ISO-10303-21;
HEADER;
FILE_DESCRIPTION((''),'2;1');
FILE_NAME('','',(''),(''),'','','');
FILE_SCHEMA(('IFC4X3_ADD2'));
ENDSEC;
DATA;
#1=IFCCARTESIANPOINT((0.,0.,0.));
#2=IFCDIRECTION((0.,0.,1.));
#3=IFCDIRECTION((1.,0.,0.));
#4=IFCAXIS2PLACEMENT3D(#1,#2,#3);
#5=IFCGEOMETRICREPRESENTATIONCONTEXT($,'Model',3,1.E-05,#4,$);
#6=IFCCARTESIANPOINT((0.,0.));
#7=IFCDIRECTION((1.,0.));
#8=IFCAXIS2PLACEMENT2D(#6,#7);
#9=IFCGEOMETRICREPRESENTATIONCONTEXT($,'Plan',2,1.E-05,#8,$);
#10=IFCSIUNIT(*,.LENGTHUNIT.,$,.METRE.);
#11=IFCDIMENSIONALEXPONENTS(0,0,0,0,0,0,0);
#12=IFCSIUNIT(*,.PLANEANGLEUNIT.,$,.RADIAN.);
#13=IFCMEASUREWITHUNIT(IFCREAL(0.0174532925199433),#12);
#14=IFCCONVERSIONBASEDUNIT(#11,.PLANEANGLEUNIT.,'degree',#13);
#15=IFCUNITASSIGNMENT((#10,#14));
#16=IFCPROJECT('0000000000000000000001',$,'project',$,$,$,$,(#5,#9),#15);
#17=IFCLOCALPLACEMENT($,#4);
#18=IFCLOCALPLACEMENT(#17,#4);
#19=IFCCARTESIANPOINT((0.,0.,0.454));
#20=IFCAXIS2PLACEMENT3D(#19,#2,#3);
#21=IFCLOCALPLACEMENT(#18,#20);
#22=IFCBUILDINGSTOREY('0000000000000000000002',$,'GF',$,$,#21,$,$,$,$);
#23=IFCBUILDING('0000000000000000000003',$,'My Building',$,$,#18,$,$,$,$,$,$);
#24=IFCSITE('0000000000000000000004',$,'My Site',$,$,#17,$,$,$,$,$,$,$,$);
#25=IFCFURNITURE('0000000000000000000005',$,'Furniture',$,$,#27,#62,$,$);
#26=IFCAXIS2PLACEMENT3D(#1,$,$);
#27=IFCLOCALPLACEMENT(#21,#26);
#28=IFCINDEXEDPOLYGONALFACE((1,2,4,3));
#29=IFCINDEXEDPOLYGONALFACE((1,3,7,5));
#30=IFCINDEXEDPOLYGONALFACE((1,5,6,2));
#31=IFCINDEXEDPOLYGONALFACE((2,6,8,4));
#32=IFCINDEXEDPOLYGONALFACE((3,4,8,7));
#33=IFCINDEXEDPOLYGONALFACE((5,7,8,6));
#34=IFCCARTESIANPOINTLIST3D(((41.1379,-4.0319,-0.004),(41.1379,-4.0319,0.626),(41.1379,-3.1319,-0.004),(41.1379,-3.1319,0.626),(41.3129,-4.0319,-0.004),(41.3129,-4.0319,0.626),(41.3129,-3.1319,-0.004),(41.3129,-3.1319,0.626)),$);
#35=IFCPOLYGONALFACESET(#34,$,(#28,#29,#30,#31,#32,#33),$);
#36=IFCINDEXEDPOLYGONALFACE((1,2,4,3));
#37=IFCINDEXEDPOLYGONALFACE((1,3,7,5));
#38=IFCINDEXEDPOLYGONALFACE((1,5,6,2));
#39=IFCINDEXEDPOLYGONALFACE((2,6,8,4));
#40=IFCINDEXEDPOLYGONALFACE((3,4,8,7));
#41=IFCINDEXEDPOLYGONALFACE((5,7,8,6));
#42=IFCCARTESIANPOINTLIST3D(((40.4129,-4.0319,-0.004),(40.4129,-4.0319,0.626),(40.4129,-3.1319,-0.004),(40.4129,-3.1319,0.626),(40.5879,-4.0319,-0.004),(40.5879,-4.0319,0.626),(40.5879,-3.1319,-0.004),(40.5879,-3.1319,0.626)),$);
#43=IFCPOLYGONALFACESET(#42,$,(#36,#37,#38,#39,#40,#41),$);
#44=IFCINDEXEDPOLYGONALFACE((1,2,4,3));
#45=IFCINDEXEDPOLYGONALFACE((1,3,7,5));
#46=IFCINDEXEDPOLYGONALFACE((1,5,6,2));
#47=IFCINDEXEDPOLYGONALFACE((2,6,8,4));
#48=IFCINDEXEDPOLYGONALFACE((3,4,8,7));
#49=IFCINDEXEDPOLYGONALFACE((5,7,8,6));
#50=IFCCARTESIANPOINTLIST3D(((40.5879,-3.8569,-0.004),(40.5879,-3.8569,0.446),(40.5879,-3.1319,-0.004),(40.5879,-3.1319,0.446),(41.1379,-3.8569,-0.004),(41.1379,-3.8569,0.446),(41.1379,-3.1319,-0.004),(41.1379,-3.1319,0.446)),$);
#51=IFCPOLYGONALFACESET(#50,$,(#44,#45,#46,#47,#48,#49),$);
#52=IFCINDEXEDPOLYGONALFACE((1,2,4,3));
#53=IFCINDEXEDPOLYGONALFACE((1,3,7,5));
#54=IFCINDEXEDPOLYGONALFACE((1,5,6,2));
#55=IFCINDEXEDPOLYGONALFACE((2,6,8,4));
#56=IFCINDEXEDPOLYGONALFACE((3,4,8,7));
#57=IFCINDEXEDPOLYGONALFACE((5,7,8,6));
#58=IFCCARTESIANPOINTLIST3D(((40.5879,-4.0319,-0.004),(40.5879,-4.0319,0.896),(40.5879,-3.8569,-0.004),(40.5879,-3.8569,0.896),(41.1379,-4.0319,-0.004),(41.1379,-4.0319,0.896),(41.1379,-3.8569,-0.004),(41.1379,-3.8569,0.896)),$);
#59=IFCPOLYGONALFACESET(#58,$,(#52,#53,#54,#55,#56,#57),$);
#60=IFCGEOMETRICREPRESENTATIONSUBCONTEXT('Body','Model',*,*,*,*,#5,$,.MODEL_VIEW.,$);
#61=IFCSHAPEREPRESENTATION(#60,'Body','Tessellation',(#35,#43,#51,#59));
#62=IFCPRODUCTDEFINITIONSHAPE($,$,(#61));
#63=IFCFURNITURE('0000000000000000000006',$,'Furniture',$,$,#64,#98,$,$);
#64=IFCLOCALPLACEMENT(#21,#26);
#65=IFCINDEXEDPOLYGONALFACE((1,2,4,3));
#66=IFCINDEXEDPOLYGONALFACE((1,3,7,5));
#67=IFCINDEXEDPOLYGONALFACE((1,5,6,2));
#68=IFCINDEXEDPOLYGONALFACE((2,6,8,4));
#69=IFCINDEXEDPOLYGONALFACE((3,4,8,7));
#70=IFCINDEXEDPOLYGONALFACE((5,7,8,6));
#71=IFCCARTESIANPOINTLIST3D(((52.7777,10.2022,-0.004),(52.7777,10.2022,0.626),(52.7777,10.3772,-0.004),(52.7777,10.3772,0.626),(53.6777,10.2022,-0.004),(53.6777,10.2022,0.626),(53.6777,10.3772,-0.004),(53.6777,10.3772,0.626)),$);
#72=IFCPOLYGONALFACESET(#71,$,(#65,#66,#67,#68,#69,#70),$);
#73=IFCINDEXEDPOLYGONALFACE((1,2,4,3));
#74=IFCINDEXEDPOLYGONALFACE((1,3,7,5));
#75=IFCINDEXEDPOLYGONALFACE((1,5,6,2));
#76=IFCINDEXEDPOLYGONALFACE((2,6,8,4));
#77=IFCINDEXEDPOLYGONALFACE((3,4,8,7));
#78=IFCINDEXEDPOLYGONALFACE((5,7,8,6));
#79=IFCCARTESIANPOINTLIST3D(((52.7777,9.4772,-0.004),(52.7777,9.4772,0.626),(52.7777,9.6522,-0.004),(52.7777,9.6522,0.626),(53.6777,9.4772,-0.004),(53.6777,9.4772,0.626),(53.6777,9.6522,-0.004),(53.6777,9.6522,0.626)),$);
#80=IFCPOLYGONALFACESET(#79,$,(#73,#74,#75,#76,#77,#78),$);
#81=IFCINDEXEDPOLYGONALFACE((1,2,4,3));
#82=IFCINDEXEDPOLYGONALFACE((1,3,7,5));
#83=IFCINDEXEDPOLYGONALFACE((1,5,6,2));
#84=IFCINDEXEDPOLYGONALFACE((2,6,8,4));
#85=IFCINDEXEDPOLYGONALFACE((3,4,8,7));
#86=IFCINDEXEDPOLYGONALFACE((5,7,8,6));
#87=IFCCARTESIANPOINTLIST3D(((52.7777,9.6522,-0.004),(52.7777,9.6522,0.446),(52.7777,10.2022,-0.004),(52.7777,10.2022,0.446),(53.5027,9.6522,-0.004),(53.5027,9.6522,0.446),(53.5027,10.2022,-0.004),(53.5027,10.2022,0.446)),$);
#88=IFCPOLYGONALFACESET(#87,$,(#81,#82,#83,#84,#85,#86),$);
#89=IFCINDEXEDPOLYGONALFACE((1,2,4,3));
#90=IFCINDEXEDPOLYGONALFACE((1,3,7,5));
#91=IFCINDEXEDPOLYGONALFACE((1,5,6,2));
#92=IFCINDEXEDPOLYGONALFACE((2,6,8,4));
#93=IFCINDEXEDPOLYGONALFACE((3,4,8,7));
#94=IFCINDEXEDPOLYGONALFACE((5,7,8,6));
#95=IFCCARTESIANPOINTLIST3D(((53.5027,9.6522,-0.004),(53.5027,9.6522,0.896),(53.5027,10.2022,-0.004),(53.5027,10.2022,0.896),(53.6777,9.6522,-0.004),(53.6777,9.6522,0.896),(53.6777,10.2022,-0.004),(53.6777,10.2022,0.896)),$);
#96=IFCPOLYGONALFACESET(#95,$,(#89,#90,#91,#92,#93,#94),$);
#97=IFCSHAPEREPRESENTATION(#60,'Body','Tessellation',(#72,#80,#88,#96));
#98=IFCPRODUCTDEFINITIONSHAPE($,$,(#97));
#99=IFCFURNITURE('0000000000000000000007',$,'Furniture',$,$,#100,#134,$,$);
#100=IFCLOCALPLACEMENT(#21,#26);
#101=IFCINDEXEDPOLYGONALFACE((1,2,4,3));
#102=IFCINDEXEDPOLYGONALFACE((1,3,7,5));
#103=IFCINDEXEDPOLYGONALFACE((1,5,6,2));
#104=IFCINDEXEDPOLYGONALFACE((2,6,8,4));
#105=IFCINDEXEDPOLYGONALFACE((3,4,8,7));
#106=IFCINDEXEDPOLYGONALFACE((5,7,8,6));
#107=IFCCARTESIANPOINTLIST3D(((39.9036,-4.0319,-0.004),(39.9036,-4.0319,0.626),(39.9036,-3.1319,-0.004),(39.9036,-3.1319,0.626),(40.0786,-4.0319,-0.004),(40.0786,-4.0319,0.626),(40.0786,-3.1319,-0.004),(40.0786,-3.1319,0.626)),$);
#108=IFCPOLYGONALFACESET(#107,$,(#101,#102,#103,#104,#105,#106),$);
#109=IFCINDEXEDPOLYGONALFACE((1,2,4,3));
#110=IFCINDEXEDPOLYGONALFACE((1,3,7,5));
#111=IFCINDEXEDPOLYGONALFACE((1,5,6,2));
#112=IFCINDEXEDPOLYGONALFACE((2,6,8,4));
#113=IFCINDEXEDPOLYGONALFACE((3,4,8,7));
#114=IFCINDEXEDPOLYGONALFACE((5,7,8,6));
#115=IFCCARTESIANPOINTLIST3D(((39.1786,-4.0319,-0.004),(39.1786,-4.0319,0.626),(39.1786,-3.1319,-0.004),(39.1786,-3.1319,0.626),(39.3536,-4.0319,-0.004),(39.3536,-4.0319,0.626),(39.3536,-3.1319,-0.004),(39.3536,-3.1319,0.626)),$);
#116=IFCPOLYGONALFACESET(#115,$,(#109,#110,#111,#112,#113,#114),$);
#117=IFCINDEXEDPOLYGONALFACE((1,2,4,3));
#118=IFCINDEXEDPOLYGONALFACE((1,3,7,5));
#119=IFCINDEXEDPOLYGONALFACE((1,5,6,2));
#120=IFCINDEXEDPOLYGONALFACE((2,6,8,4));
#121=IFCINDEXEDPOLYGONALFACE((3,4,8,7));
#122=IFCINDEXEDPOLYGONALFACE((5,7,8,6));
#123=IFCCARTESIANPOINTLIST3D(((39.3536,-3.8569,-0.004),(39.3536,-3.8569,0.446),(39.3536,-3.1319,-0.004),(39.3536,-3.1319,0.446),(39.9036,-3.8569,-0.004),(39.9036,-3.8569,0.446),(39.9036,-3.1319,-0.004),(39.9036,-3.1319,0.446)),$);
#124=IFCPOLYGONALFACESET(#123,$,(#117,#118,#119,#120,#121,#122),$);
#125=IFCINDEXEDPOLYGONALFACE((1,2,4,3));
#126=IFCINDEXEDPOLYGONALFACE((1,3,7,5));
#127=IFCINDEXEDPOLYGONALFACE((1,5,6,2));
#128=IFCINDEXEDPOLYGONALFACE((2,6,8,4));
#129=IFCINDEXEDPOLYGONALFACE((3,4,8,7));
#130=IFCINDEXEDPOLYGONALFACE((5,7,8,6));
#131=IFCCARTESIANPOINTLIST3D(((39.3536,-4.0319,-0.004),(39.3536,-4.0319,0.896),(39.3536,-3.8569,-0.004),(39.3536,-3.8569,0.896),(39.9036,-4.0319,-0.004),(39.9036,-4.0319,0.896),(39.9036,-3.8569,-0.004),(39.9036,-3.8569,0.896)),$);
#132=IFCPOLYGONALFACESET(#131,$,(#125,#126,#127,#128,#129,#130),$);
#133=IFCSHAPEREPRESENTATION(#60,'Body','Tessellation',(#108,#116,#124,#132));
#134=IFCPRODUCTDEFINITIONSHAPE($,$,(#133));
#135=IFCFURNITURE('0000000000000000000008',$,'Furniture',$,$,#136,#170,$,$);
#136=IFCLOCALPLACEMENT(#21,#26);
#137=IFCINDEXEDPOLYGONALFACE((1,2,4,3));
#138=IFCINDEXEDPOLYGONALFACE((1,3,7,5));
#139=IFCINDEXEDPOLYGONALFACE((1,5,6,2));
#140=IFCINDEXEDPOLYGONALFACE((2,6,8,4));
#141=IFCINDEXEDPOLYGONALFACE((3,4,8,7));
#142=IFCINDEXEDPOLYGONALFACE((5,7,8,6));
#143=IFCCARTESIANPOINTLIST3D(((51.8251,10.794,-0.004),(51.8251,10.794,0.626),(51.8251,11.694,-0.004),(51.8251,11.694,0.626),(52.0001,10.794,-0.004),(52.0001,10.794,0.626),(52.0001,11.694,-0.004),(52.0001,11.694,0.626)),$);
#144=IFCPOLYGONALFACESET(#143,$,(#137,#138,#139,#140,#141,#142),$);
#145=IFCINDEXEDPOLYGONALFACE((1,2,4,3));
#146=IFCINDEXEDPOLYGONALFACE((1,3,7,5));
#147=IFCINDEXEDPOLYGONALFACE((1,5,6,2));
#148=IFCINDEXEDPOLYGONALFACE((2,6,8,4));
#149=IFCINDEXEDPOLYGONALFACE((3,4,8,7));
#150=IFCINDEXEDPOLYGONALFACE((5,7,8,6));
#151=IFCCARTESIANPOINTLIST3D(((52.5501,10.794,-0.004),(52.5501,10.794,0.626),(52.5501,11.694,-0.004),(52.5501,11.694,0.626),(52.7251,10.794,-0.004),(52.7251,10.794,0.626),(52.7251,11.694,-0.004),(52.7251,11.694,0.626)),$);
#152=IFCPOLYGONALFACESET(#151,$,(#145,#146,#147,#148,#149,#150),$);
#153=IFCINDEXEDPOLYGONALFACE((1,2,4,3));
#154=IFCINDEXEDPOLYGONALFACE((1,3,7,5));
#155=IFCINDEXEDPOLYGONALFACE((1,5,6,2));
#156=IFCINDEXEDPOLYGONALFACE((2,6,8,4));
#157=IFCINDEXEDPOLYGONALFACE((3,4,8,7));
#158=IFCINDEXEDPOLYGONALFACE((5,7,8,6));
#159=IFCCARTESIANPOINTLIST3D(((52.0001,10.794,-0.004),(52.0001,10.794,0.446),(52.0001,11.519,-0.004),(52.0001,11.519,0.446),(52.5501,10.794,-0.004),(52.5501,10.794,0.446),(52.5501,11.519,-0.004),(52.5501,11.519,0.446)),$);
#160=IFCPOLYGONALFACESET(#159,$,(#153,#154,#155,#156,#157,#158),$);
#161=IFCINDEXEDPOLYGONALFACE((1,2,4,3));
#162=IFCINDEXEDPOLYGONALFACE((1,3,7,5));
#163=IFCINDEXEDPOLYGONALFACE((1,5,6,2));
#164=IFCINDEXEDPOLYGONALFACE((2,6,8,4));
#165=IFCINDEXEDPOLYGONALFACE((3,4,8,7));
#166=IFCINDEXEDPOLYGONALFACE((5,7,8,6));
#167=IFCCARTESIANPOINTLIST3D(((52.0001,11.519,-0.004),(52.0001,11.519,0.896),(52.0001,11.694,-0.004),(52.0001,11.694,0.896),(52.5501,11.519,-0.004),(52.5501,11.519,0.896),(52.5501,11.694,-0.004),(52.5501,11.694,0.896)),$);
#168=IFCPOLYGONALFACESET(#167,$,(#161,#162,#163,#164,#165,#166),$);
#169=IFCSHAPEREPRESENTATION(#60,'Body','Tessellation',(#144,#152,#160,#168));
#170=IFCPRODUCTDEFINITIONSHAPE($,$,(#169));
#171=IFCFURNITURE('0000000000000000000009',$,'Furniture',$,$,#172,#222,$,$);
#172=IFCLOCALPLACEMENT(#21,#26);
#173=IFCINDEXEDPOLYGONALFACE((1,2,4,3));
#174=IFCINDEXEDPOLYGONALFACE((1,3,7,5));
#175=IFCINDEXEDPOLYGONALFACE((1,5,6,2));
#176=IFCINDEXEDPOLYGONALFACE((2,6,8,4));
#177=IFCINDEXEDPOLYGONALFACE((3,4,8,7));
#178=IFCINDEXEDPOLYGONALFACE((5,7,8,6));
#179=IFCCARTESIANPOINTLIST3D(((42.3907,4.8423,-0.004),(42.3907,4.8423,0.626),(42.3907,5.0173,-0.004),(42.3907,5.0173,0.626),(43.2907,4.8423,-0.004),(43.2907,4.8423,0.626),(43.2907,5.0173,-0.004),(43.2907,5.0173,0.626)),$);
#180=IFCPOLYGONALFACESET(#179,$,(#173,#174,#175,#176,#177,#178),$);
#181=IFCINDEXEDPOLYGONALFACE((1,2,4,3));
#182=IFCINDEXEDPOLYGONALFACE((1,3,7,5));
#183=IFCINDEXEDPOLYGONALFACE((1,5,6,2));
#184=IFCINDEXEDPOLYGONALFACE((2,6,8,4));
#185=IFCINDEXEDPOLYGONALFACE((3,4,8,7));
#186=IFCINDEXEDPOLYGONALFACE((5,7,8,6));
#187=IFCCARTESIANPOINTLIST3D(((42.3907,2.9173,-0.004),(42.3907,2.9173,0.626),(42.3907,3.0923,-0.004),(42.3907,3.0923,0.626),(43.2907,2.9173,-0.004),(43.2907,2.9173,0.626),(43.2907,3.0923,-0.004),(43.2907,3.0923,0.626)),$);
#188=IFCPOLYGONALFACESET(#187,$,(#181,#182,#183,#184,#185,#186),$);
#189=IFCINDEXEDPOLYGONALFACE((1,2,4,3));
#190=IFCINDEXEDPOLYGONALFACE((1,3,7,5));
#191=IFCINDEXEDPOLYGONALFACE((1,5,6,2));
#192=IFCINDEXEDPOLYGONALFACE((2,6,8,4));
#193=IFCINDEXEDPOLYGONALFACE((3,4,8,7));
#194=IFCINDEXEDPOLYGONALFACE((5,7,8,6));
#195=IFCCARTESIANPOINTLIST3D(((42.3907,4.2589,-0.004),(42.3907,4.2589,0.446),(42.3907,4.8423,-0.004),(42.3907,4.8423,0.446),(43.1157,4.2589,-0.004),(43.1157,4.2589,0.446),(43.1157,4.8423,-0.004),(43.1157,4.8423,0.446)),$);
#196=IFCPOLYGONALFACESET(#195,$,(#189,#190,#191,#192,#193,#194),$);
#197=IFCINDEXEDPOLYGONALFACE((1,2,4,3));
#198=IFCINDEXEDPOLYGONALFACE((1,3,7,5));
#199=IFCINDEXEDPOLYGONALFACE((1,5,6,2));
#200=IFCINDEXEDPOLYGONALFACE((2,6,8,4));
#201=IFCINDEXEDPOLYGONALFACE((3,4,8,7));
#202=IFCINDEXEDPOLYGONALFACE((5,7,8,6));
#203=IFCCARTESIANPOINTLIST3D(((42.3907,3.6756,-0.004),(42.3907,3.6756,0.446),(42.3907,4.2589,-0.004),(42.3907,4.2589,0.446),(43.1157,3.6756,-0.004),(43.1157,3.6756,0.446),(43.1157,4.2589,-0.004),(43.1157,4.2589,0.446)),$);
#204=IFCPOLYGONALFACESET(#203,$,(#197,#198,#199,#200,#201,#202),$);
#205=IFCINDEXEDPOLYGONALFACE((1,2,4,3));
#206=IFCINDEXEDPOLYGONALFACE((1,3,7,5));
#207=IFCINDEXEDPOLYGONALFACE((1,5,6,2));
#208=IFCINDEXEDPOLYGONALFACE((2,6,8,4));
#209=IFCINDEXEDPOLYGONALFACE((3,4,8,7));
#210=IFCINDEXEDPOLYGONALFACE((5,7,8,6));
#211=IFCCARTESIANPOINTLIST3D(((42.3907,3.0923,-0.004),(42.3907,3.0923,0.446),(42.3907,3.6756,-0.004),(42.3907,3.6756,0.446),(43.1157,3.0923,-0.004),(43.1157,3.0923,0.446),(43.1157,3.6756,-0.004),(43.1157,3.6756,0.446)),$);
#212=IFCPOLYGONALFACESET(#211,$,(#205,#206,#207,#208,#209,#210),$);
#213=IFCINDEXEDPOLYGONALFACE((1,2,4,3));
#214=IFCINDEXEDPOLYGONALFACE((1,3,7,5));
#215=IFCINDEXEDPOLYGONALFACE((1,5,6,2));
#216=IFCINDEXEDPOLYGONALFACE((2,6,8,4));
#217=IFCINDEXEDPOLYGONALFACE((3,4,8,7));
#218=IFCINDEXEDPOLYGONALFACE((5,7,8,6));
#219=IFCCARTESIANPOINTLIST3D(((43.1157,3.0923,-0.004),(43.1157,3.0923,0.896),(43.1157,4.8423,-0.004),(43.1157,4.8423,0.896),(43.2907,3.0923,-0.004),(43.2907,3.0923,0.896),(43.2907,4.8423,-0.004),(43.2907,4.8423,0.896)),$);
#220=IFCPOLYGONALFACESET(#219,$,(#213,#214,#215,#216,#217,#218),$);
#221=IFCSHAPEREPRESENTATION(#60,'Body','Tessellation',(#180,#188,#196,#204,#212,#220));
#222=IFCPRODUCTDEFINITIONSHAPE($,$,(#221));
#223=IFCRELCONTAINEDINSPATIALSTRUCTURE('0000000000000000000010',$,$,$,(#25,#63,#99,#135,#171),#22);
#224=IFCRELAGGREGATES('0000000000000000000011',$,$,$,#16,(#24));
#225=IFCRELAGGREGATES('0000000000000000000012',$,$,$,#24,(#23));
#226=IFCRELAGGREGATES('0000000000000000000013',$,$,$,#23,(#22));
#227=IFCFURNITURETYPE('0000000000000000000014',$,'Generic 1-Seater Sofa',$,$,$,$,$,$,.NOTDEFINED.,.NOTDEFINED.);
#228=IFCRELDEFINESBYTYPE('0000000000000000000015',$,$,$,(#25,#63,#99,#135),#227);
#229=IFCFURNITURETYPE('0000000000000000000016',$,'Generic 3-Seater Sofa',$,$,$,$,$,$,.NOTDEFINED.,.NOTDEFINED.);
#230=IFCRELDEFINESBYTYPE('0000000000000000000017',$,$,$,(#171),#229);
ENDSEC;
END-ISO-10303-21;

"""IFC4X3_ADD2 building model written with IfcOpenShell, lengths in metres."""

from ifc_helpers import new_model, entity, si_unit, converted_unit, frame, origin_with_axes, origin_2d_with_axis, place, context, subcontext, project, spatial, line, indexed_curve, outline, extrude, shape, source, transform, mapped, type_object, type_shapes, element, save


model = new_model("IFC4X3_ADD2")

# Units and contexts
model_context = context("Model", 3, precision=1e-05, world=origin_with_axes())
plan_context = context("Plan", 2, precision=1e-05, world=origin_2d_with_axis())
body_context_1 = subcontext(model_context, "Body", "Model", "MODEL_VIEW")
body_context_2 = subcontext(plan_context, "Body", "Plan", "PLAN_VIEW")
ifc_project = project(units=[si_unit("LENGTHUNIT", "METRE"), converted_unit("PLANEANGLEUNIT", "degree", entity("IfcReal", 0.0174532925199433), si_unit("PLANEANGLEUNIT", "RADIAN"), dimensions=[0, 0, 0, 0, 0, 0, 0])], contexts=[model_context, plan_context])

# Site, building, storey
site_placement = place(None, origin_with_axes())
site = spatial("IfcSite", under=ifc_project, at=site_placement, Name="My Site")
building_placement = place(site_placement, origin_with_axes())
building = spatial("IfcBuilding", under=site, at=building_placement, Name="My Building")
storey_placement = place(building_placement, frame((0.0, 0.0, 0.454), z_axis=(0.0, 0.0, 1.0), x_axis=(1.0, 0.0, 0.0)))
storey = spatial("IfcBuildingStorey", under=building, at=storey_placement, Name="GF")

# Furniture
furniture_type_1 = type_object("IfcFurnitureType", Name="Generic 1-Seater Sofa", AssemblyPlace="NOTDEFINED", PredefinedType="NOTDEFINED")
shared_shape_1 = source(origin_with_axes(), body_context_1, "Body", "SweptSolid", [
    extrude(outline(indexed_curve([(0.0, 0.0), (0.175, 0.0), (0.175, 0.9), (0.0, 0.9)], segments=[line(1, 2, 3, 4, 1)])), frame((-0.45, -0.9, 0.0), z_axis=(0.0, 0.0, 1.0), x_axis=(1.0, 0.0, 0.0)), (0.0, 0.0, 1.0), 0.63),
    extrude(outline(indexed_curve([(0.0, 0.0), (0.175, 0.0), (0.175, 0.9), (0.0, 0.9)], segments=[line(1, 2, 3, 4, 1)])), frame((0.275, -0.9, 0.0), z_axis=(0.0, 0.0, 1.0), x_axis=(1.0, 0.0, 0.0)), (0.0, 0.0, 1.0), 0.63),
    extrude(outline(indexed_curve([(0.175, 0.0), (0.725, 0.0), (0.725, 0.725), (0.175, 0.725)], segments=[line(1, 2, 3, 4, 1)])), frame((-0.45, -0.9, 0.0), z_axis=(0.0, 0.0, 1.0), x_axis=(1.0, 0.0, 0.0)), (0.0, 0.0, 1.0), 0.45),
    extrude(outline(indexed_curve([(0.175, 0.725), (0.725, 0.725), (0.725, 0.9), (0.175, 0.9)], segments=[line(1, 2, 3, 4, 1)])), frame((-0.45, -0.9, 0.0), z_axis=(0.0, 0.0, 1.0), x_axis=(1.0, 0.0, 0.0)), (0.0, 0.0, 1.0), 0.9),
])
shared_shape_2 = source(origin_with_axes(), body_context_2, "Body", "Annotation2D", [
    entity("IfcGeometricCurveSet", [entity("IfcIndexedPolyCurve", entity("IfcCartesianPointList2D", [[0.275, -0.175], [0.275, -0.9], [0.45, -0.9], [0.45, 0.0], [0.275, 0.0], [0.275, -0.9], [-0.275, -0.9], [-0.275, 0.0], [-0.275, -0.175], [0.275, -0.175], [0.275, 0.0], [-0.275, 0.0], [-0.45, 0.0], [-0.45, -0.9], [-0.275, -0.9], [-0.275, -0.175]]))]),
])
type_shapes(furniture_type_1, [shared_shape_1, shared_shape_2])
for number, where, z_axis, x_axis, name in (
    (1, (40.8629, -4.0319, -0.004), (0.0, 0.0, 1.0), (-1.0, 0.0, 0.0), "Furniture"),
    (2, (53.6777, 9.9272, -0.004), (0.0, 0.0, 1.0), (0.0, -1.0, 0.0), "Furniture"),
    (3, (39.6286, -4.0319, -0.004), (0.0, 0.0, 1.0), (-1.0, 0.0, 0.0), "Furniture"),
    (4, (52.2751, 11.694, -0.004), (0.0, 0.0, 1.0), (1.0, 0.0, 0.0), "Furniture"),
):
    element("IfcFurniture", number, at=place(storey_placement, frame(where, z_axis=z_axis, x_axis=x_axis)), inside=storey, type_object=furniture_type_1, Name=name, shapes=[
        shape(body_context_1, "Body", "MappedRepresentation", [mapped(shared_shape_1, transform((0.0, 0.0, 0.0), x_axis=(1.0, 0.0, 0.0), y_axis=(0.0, 1.0, 0.0), z_axis=(0.0, 0.0, 1.0), scale=1.0))]),
        shape(body_context_2, "Body", "MappedRepresentation", [mapped(shared_shape_2, transform((0.0, 0.0, 0.0), x_axis=(1.0, 0.0, 0.0), y_axis=(0.0, 1.0, 0.0), z_axis=(0.0, 0.0, 1.0), scale=1.0))]),
    ])
furniture_type_2 = type_object("IfcFurnitureType", Name="Generic 3-Seater Sofa", AssemblyPlace="NOTDEFINED", PredefinedType="NOTDEFINED")
shared_shape_3 = source(origin_with_axes(), body_context_1, "Body", "SweptSolid", [
    extrude(outline(indexed_curve([(0.0, 0.0), (0.175, 0.0), (0.175, 0.9), (0.0, 0.9)], segments=[line(4, 1), line(1, 2), line(2, 3), line(3, 4)], self_intersect=False)), frame((-1.05, -0.9, 0.0), z_axis=(0.0, 0.0, 1.0), x_axis=(1.0, 0.0, 0.0)), (0.0, 0.0, 1.0), 0.63),
    extrude(outline(indexed_curve([(0.0, 0.0), (0.175, 0.0), (0.175, 0.9), (0.0, 0.9)], segments=[line(1, 2, 3, 4, 1)])), frame((0.875, -0.9, 0.0), z_axis=(0.0, 0.0, 1.0), x_axis=(1.0, 0.0, 0.0)), (0.0, 0.0, 1.0), 0.63),
    extrude(outline(indexed_curve([(0.175, 0.0), (0.7583, 0.0), (0.7583, 0.725), (0.175, 0.725)], segments=[line(1, 2, 3, 4, 1)])), frame((-1.05, -0.9, 0.0), z_axis=(0.0, 0.0, 1.0), x_axis=(1.0, 0.0, 0.0)), (0.0, 0.0, 1.0), 0.45),
    extrude(outline(indexed_curve([(0.7583, 0.0), (1.3417, 0.0), (1.3417, 0.725), (0.7583, 0.725)], segments=[line(1, 2, 3, 4, 1)])), frame((-1.05, -0.9, 0.0), z_axis=(0.0, 0.0, 1.0), x_axis=(1.0, 0.0, 0.0)), (0.0, 0.0, 1.0), 0.45),
    extrude(outline(indexed_curve([(1.3417, 0.0), (1.925, 0.0), (1.925, 0.725), (1.3417, 0.725)], segments=[line(1, 2, 3, 4, 1)])), frame((-1.05, -0.9, 0.0), z_axis=(0.0, 0.0, 1.0), x_axis=(1.0, 0.0, 0.0)), (0.0, 0.0, 1.0), 0.45),
    extrude(outline(indexed_curve([(0.175, 0.725), (1.925, 0.725), (1.925, 0.9), (0.175, 0.9)], segments=[line(1, 2, 3, 4, 1)])), frame((-1.05, -0.9, 0.0), z_axis=(0.0, 0.0, 1.0), x_axis=(1.0, 0.0, 0.0)), (0.0, 0.0, 1.0), 0.9),
])
shared_shape_4 = source(origin_with_axes(), body_context_2, "Body", "Annotation2D", [
    entity("IfcGeometricCurveSet", [entity("IfcIndexedPolyCurve", entity("IfcCartesianPointList2D", [[0.2917, -0.175], [0.2917, -0.9], [0.875, -0.9], [0.875, -0.175], [-0.875, -0.175], [-0.875, 0.0], [0.875, 0.0], [1.05, 0.0], [1.05, -0.9], [0.875, -0.9], [0.875, 0.0], [0.875, -0.175], [0.2917, -0.175], [-0.2917, -0.175], [-0.2917, -0.9], [-0.875, -0.9], [-0.875, 0.0], [-1.05, 0.0], [-1.05, -0.9], [-0.875, -0.9], [-0.875, -0.175], [-0.2917, -0.175]])), entity("IfcIndexedPolyCurve", entity("IfcCartesianPointList2D", [[0.2917, -0.9], [-0.2917, -0.9]]))]),
])
type_shapes(furniture_type_2, [shared_shape_3, shared_shape_4])
furniture_1_placement = place(storey_placement, frame((43.2907, 3.9673, -0.004), z_axis=(0.0, 0.0, 1.0), x_axis=(0.0, -1.0, 0.0)))
element("IfcFurniture", 5, at=furniture_1_placement, inside=storey, type_object=furniture_type_2, Name="Furniture", shapes=[
    shape(body_context_1, "Body", "MappedRepresentation", [mapped(shared_shape_3, transform((0.0, 0.0, 0.0), x_axis=(1.0, 0.0, 0.0), y_axis=(0.0, 1.0, 0.0), z_axis=(0.0, 0.0, 1.0), scale=1.0))]),
    shape(body_context_2, "Body", "MappedRepresentation", [mapped(shared_shape_4, transform((0.0, 0.0, 0.0), x_axis=(1.0, 0.0, 0.0), y_axis=(0.0, 1.0, 0.0), z_axis=(0.0, 0.0, 1.0), scale=1.0))]),
])

save(model, "model.ifc")
